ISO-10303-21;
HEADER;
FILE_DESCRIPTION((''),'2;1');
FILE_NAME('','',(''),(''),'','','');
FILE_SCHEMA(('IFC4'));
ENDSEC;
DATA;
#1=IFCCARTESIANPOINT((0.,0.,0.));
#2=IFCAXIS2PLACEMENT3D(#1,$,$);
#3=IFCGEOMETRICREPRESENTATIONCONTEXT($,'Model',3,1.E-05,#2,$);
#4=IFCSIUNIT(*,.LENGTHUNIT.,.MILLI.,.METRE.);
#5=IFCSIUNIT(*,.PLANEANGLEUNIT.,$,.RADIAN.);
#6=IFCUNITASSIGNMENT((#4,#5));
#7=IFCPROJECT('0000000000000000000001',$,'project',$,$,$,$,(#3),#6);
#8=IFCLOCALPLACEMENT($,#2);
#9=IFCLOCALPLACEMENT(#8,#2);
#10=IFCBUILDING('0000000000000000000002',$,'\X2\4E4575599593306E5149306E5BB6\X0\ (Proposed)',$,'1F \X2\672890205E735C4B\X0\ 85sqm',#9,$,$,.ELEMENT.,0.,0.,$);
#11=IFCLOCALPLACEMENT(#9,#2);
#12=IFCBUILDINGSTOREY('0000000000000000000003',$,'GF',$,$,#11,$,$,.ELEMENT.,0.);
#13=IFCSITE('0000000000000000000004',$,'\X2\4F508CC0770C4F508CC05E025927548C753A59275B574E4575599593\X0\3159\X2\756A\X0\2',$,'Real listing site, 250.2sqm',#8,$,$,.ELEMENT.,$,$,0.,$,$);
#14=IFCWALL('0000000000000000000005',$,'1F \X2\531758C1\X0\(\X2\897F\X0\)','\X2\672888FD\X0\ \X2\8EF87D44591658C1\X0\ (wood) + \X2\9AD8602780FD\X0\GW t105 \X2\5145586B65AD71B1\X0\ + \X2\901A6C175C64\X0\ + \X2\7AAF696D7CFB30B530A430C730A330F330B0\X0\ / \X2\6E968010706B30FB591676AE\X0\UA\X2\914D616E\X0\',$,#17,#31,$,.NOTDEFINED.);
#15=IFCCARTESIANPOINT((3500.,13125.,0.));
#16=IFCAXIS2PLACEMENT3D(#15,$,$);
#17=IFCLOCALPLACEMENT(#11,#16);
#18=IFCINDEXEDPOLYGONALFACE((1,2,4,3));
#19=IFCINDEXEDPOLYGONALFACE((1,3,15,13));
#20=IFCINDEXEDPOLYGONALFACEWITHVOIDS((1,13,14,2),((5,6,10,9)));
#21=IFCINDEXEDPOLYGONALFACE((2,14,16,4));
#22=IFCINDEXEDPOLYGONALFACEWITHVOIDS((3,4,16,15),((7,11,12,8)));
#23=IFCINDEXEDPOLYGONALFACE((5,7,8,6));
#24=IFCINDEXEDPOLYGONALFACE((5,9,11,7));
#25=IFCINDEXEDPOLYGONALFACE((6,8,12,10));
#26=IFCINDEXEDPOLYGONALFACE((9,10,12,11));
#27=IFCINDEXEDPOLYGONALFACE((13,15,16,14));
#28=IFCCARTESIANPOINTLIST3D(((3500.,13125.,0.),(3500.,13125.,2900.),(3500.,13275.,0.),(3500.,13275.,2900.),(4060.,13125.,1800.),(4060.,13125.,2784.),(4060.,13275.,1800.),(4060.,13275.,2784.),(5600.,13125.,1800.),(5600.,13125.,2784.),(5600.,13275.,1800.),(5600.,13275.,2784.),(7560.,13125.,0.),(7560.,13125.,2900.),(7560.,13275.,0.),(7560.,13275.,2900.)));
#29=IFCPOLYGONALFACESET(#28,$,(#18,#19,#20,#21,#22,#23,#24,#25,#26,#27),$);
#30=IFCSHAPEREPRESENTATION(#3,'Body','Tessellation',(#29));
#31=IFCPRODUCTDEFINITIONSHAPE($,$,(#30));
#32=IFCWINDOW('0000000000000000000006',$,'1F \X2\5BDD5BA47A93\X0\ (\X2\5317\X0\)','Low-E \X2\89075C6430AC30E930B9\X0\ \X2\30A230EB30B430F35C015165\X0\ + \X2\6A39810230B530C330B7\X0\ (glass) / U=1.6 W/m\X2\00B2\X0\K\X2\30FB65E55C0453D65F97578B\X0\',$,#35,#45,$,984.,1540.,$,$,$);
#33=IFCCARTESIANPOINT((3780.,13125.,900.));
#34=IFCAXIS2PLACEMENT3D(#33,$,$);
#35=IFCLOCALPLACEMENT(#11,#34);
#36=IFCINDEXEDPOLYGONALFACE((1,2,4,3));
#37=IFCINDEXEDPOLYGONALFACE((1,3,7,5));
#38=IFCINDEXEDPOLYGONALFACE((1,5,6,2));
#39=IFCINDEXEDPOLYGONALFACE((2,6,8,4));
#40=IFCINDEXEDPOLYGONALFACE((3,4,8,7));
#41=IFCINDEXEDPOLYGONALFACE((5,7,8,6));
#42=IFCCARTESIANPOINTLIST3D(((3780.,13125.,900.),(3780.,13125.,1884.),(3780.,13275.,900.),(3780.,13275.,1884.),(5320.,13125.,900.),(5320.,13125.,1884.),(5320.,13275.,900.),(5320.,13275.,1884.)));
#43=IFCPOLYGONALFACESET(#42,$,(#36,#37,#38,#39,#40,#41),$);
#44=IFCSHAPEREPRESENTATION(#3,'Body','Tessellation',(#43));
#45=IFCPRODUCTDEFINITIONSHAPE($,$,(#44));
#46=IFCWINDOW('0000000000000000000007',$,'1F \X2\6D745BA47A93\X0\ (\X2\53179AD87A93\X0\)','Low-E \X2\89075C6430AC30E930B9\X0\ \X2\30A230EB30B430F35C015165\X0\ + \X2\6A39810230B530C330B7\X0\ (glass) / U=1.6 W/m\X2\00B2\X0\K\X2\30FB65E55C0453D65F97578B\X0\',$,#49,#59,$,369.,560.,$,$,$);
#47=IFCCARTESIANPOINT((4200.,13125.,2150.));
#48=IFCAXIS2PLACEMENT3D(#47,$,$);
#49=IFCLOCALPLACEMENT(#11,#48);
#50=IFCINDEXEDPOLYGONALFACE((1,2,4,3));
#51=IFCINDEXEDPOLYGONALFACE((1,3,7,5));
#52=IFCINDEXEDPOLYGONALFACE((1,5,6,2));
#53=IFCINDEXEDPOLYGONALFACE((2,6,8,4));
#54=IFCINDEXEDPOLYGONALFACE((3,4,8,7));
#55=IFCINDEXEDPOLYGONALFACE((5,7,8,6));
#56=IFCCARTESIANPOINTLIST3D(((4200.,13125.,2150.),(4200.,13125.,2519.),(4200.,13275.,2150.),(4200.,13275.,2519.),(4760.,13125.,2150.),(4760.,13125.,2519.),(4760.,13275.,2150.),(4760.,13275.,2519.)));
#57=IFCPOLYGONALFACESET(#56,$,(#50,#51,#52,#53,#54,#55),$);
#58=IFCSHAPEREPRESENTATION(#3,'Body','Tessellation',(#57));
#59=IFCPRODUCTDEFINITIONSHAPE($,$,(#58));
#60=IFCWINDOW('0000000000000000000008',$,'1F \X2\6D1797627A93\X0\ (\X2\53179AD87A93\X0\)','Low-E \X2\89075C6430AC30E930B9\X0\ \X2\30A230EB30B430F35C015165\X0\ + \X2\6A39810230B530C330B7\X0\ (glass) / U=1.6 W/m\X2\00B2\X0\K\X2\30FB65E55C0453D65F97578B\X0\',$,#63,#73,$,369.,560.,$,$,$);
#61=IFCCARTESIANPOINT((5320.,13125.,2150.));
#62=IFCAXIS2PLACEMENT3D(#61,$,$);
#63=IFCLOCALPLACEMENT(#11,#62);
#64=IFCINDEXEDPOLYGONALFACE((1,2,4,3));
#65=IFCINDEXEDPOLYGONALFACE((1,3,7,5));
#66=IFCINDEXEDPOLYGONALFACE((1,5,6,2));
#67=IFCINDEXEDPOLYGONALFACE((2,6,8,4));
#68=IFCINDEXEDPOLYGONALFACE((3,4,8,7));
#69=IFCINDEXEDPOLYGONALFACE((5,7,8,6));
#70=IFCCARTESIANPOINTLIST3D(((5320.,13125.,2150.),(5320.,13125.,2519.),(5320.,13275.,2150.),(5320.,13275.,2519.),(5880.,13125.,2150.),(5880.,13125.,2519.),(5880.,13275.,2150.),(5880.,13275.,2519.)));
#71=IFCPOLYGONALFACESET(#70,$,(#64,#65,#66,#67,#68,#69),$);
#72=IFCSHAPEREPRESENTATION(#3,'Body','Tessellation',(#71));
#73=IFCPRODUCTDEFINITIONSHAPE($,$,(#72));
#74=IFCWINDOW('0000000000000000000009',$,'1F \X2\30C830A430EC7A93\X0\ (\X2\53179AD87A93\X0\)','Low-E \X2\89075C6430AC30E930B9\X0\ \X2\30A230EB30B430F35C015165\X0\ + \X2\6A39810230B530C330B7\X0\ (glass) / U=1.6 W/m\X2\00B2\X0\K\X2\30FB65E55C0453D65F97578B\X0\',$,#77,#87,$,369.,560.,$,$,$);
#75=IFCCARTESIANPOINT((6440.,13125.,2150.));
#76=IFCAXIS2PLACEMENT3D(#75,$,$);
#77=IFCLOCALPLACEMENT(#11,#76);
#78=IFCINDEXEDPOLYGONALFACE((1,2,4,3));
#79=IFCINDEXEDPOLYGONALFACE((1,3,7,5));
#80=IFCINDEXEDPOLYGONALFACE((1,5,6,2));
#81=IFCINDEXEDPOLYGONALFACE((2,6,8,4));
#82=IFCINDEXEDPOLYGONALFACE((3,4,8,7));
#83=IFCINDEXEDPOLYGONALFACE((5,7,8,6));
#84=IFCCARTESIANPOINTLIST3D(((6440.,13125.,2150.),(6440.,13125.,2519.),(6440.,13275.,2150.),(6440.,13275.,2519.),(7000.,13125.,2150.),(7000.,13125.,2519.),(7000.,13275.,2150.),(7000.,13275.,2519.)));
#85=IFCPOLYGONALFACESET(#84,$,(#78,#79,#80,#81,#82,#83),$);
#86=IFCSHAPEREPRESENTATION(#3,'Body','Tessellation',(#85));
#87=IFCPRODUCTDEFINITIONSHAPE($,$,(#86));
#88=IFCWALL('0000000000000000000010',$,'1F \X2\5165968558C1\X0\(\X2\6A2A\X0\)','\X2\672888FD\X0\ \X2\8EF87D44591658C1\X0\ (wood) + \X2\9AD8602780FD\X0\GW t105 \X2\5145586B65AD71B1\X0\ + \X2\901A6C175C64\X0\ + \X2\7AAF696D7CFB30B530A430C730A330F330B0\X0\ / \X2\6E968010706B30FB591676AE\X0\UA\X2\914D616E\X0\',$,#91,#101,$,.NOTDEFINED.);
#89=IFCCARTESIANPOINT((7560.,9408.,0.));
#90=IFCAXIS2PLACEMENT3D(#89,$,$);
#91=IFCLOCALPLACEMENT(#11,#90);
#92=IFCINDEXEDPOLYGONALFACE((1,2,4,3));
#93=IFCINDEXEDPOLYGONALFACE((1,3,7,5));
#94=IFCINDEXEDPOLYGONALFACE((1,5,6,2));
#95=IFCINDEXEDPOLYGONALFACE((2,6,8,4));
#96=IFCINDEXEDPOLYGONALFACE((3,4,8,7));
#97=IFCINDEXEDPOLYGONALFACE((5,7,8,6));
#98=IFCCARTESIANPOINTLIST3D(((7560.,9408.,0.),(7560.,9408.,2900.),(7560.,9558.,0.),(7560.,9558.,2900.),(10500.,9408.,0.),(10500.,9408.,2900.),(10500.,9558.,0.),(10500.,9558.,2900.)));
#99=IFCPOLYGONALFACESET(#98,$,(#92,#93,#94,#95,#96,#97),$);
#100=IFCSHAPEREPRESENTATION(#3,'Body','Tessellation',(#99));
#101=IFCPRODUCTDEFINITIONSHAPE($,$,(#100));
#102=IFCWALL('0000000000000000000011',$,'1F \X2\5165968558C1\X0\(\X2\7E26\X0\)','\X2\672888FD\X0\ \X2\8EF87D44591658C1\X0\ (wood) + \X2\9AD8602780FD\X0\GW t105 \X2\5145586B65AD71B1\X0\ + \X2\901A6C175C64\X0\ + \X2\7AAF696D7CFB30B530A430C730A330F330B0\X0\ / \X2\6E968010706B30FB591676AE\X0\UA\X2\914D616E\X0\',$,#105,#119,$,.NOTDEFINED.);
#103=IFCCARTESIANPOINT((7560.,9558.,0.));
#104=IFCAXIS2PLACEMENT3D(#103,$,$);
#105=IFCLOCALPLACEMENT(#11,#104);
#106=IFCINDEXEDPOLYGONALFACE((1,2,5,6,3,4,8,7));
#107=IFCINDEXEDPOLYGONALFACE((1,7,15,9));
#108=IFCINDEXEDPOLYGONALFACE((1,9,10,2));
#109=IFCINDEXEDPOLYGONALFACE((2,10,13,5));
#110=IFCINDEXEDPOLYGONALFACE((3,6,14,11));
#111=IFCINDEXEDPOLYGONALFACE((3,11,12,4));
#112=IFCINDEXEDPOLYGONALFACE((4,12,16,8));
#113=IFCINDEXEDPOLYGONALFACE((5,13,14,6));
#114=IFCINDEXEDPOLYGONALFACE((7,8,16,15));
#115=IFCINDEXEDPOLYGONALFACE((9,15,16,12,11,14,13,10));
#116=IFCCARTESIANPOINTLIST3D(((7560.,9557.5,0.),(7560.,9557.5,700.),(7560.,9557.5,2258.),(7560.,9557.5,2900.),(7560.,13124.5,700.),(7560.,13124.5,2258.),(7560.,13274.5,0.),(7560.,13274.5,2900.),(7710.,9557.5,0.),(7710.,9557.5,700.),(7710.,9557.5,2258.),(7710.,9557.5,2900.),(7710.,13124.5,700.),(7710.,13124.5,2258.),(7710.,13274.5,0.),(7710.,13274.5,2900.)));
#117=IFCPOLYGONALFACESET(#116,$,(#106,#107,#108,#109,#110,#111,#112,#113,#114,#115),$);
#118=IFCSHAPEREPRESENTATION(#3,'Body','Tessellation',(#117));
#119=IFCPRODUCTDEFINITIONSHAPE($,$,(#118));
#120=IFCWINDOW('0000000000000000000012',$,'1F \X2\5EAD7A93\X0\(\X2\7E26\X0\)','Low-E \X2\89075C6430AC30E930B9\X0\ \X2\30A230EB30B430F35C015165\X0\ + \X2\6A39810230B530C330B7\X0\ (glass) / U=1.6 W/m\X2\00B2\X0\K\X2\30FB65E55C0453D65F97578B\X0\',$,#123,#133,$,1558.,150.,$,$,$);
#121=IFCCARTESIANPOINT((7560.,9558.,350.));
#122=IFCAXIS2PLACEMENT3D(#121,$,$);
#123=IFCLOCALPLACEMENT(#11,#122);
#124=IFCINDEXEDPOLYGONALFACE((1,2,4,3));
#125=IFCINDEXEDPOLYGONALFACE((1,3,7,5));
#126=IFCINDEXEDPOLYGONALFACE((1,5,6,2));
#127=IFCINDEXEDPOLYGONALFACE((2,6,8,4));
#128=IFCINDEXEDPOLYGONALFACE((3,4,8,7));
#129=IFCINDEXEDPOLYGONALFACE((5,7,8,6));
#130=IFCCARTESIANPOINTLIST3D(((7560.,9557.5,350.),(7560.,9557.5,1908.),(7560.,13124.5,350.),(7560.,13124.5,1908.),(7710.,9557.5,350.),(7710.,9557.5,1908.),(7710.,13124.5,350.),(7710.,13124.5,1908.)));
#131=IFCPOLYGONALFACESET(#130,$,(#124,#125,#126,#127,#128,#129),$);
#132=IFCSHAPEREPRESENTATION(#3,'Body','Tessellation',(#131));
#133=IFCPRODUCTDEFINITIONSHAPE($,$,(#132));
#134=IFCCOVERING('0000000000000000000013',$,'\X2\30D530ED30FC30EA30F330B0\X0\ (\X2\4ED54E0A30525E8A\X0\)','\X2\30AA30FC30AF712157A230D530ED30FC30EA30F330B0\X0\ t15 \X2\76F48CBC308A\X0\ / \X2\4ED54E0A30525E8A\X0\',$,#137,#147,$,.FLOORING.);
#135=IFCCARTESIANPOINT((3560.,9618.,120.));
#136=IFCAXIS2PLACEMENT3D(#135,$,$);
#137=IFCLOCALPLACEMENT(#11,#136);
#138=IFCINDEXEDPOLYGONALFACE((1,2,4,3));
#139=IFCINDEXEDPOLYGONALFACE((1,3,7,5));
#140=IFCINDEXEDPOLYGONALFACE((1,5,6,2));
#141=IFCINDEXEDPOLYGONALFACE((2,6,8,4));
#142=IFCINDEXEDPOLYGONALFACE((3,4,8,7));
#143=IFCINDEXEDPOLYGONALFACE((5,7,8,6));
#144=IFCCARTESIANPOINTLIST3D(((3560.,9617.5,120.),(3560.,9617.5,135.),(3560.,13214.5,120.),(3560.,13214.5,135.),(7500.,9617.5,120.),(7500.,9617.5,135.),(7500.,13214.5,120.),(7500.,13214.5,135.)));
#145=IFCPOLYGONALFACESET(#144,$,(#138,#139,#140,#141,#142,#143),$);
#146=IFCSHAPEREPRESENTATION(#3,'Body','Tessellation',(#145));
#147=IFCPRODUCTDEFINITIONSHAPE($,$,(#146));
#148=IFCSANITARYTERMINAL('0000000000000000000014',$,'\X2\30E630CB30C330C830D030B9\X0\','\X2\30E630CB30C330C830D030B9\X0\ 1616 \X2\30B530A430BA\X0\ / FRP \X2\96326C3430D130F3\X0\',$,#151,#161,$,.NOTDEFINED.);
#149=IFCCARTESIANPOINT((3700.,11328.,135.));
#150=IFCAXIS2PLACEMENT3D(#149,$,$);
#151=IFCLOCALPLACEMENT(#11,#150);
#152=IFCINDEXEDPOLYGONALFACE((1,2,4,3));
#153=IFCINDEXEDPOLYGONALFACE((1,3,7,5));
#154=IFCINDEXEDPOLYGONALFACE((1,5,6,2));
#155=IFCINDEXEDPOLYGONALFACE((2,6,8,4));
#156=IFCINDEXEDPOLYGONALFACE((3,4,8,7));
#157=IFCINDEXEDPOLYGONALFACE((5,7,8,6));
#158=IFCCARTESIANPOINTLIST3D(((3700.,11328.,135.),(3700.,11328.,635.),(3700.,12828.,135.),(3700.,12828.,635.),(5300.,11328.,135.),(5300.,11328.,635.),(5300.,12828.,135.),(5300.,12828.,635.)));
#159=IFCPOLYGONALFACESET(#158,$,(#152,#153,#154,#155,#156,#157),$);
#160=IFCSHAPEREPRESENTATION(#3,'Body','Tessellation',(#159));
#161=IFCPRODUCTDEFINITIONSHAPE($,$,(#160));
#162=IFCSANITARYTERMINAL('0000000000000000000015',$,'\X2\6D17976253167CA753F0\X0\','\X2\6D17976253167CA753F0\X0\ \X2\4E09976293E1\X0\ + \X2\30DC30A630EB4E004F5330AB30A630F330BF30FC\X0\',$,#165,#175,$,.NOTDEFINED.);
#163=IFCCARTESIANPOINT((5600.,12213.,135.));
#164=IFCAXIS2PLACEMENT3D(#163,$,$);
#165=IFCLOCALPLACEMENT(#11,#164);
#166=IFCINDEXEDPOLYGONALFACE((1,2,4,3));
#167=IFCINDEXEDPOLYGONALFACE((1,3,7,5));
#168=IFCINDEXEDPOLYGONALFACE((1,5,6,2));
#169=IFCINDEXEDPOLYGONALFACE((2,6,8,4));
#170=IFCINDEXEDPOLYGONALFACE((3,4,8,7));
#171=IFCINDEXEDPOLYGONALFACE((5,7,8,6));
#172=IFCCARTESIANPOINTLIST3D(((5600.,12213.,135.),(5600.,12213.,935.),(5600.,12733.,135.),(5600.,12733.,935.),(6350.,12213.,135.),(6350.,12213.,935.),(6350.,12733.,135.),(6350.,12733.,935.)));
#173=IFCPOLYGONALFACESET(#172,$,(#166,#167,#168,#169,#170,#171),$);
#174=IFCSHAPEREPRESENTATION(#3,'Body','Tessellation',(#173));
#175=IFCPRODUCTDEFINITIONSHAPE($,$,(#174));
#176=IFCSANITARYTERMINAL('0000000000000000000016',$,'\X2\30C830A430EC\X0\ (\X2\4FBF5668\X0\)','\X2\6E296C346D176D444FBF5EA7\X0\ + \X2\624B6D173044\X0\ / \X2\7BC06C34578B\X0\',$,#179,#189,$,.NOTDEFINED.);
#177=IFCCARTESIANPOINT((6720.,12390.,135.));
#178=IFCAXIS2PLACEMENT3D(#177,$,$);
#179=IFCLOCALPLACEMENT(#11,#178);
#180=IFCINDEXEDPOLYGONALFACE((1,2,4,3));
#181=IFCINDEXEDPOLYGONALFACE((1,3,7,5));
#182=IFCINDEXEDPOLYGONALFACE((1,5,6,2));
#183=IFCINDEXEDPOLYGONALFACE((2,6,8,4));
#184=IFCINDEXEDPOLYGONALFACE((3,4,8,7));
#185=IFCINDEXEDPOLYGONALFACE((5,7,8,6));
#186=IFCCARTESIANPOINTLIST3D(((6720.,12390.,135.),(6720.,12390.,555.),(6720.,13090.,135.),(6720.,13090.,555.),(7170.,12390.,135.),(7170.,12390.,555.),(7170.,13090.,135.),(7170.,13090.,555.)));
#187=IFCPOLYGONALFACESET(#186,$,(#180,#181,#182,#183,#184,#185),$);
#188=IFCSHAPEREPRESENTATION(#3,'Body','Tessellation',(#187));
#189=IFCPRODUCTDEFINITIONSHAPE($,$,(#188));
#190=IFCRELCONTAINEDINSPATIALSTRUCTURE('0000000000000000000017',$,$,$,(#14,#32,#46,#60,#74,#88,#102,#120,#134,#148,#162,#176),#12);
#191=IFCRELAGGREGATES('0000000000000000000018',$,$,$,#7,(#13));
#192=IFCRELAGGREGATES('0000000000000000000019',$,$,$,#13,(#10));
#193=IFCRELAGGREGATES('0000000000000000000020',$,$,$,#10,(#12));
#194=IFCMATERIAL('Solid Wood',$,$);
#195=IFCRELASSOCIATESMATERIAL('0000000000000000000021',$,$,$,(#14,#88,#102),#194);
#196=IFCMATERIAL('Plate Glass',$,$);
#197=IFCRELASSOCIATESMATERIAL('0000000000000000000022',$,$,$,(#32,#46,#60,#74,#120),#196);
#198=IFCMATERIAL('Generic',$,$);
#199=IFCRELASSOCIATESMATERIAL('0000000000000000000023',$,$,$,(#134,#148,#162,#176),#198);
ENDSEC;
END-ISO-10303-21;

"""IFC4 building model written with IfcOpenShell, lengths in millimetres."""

from ifc_helpers import new_model, si_unit, frame, frame_2d, origin, place, context, project, spatial, rectangle, extrude, material, element, fill, save


model = new_model("IFC4")

# Units and contexts
model_context = context("Model", 3, precision=1e-05, world=origin())
ifc_project = project(units=[si_unit("LENGTHUNIT", "METRE", prefix="MILLI"), si_unit("PLANEANGLEUNIT", "RADIAN")], contexts=[model_context])

# Site, building, storey
site_placement = place(None, origin())
site = spatial("IfcSite", under=ifc_project, at=site_placement, Name="佐賀県佐賀市大和町大字久留間3159番2", ObjectType="Real listing site, 250.2sqm", CompositionType="ELEMENT", RefElevation=0.0)
building_placement = place(site_placement, origin())
building = spatial("IfcBuilding", under=site, at=building_placement, Name="久留間の光の家 (Proposed)", ObjectType="1F 木造平屋 85sqm", CompositionType="ELEMENT", ElevationOfRefHeight=0.0, ElevationOfTerrain=0.0)
storey_placement = place(building_placement, origin())
storey = spatial("IfcBuildingStorey", under=building, at=storey_placement, Name="GF", CompositionType="ELEMENT", Elevation=0.0)

# Shared definitions
ifc_material_1 = material(Name="Solid Wood")

# Wall, openings, windows
wall_1_placement = place(storey_placement, frame((3500.0, 13125.0, 0.0)))
wall_1 = element("IfcWall", 1, at=wall_1_placement, inside=storey, material=ifc_material_1, Name="1F 北壁(西)", Description="木製 軸組外壁 (wood) + 高性能GW t105 充填断熱 + 通気層 + 窯業系サイディング / 準耐火・外皮UA配慮", PredefinedType="NOTDEFINED", context=model_context, shape_type="SweptSolid", body=[
    extrude(rectangle(XDim=4060.0, YDim=150.0, at=frame_2d((2030.0, 75.0))), frame((3500.0, 13125.0, 0.0)), (0.0, 0.0, 1.0), 2900.0),
])
opening_1_placement = place(storey_placement, frame((3780.0, 13125.0, 900.0)))
opening_1 = element("IfcOpeningElement", 2, at=opening_1_placement, cuts=wall_1, PredefinedType="NOTDEFINED", context=model_context, shape_type="SweptSolid", body=[
    extrude(rectangle(XDim=1540.0, YDim=150.0, at=frame_2d((770.0, 75.0))), frame((3780.0, 13125.0, 900.0)), (0.0, 0.0, 1.0), 984.0),
])
opening_2_placement = place(storey_placement, frame((4200.0, 13125.0, 2150.0)))
opening_2 = element("IfcOpeningElement", 3, at=opening_2_placement, cuts=wall_1, PredefinedType="NOTDEFINED", context=model_context, shape_type="SweptSolid", body=[
    extrude(rectangle(XDim=560.0, YDim=150.0, at=frame_2d((280.0, 75.0))), frame((4200.0, 13125.0, 2150.0)), (0.0, 0.0, 1.0), 369.0),
])
opening_3_placement = place(storey_placement, frame((5320.0, 13125.0, 2150.0)))
opening_3 = element("IfcOpeningElement", 4, at=opening_3_placement, cuts=wall_1, PredefinedType="NOTDEFINED", context=model_context, shape_type="SweptSolid", body=[
    extrude(rectangle(XDim=560.0, YDim=150.0, at=frame_2d((280.0, 75.0))), frame((5320.0, 13125.0, 2150.0)), (0.0, 0.0, 1.0), 369.0),
])
opening_4_placement = place(storey_placement, frame((6440.0, 13125.0, 2150.0)))
opening_4 = element("IfcOpeningElement", 5, at=opening_4_placement, cuts=wall_1, PredefinedType="NOTDEFINED", context=model_context, shape_type="SweptSolid", body=[
    extrude(rectangle(XDim=560.0, YDim=150.0, at=frame_2d((280.0, 75.0))), frame((6440.0, 13125.0, 2150.0)), (0.0, 0.0, 1.0), 369.0),
])
ifc_material_2 = material(Name="Plate Glass")
window_1_placement = place(storey_placement, frame((3780.0, 13125.0, 900.0)))
window_1 = element("IfcWindow", 6, at=window_1_placement, inside=storey, material=ifc_material_2, Name="1F 寝室窓 (北)", Description="Low-E 複層ガラス アルゴン封入 + 樹脂サッシ (glass) / U=1.6 W/m²K・日射取得型", OverallHeight=984.0, OverallWidth=1540.0, context=model_context, shape_type="SweptSolid", body=[
    extrude(rectangle(XDim=1540.0, YDim=150.0, at=frame_2d((770.0, 75.0))), frame((3780.0, 13125.0, 900.0)), (0.0, 0.0, 1.0), 984.0),
])
fill(opening_1, window_1)
window_2_placement = place(storey_placement, frame((4200.0, 13125.0, 2150.0)))
window_2 = element("IfcWindow", 7, at=window_2_placement, inside=storey, material=ifc_material_2, Name="1F 浴室窓 (北高窓)", Description="Low-E 複層ガラス アルゴン封入 + 樹脂サッシ (glass) / U=1.6 W/m²K・日射取得型", OverallHeight=369.0, OverallWidth=560.0, context=model_context, shape_type="SweptSolid", body=[
    extrude(rectangle(XDim=560.0, YDim=150.0, at=frame_2d((280.0, 75.0))), frame((4200.0, 13125.0, 2150.0)), (0.0, 0.0, 1.0), 369.0),
])
fill(opening_2, window_2)
window_3_placement = place(storey_placement, frame((5320.0, 13125.0, 2150.0)))
window_3 = element("IfcWindow", 8, at=window_3_placement, inside=storey, material=ifc_material_2, Name="1F 洗面窓 (北高窓)", Description="Low-E 複層ガラス アルゴン封入 + 樹脂サッシ (glass) / U=1.6 W/m²K・日射取得型", OverallHeight=369.0, OverallWidth=560.0, context=model_context, shape_type="SweptSolid", body=[
    extrude(rectangle(XDim=560.0, YDim=150.0, at=frame_2d((280.0, 75.0))), frame((5320.0, 13125.0, 2150.0)), (0.0, 0.0, 1.0), 369.0),
])
fill(opening_3, window_3)
window_4_placement = place(storey_placement, frame((6440.0, 13125.0, 2150.0)))
window_4 = element("IfcWindow", 9, at=window_4_placement, inside=storey, material=ifc_material_2, Name="1F トイレ窓 (北高窓)", Description="Low-E 複層ガラス アルゴン封入 + 樹脂サッシ (glass) / U=1.6 W/m²K・日射取得型", OverallHeight=369.0, OverallWidth=560.0, context=model_context, shape_type="SweptSolid", body=[
    extrude(rectangle(XDim=560.0, YDim=150.0, at=frame_2d((280.0, 75.0))), frame((6440.0, 13125.0, 2150.0)), (0.0, 0.0, 1.0), 369.0),
])
fill(opening_4, window_4)

# Wall
wall_2_placement = place(storey_placement, frame((7560.0, 9408.0, 0.0)))
element("IfcWall", 10, at=wall_2_placement, inside=storey, material=ifc_material_1, Name="1F 入隅壁(横)", Description="木製 軸組外壁 (wood) + 高性能GW t105 充填断熱 + 通気層 + 窯業系サイディング / 準耐火・外皮UA配慮", PredefinedType="NOTDEFINED", context=model_context, shape_type="SweptSolid", body=[
    extrude(rectangle(XDim=2940.0, YDim=150.0, at=frame_2d((1470.0, 75.0))), frame((7560.0, 9408.0, 0.0)), (0.0, 0.0, 1.0), 2900.0),
])

# Wall, opening, window
wall_3_placement = place(storey_placement, frame((7560.0, 9558.0, 0.0)))
wall_3 = element("IfcWall", 11, at=wall_3_placement, inside=storey, material=ifc_material_1, Name="1F 入隅壁(縦)", Description="木製 軸組外壁 (wood) + 高性能GW t105 充填断熱 + 通気層 + 窯業系サイディング / 準耐火・外皮UA配慮", PredefinedType="NOTDEFINED", context=model_context, shape_type="SweptSolid", body=[
    extrude(rectangle(XDim=150.0, YDim=3717.0, at=frame_2d((75.0, 1858.0))), frame((7560.0, 9558.0, 0.0)), (0.0, 0.0, 1.0), 2900.0),
])
opening_5_placement = place(storey_placement, frame((7560.0, 9558.0, 350.0)))
opening_5 = element("IfcOpeningElement", 12, at=opening_5_placement, cuts=wall_3, PredefinedType="NOTDEFINED", context=model_context, shape_type="SweptSolid", body=[
    extrude(rectangle(XDim=150.0, YDim=3567.0, at=frame_2d((75.0, 1783.0))), frame((7560.0, 9558.0, 350.0)), (0.0, 0.0, 1.0), 1558.0),
])
window_5_placement = place(storey_placement, frame((7560.0, 9558.0, 350.0)))
window_5 = element("IfcWindow", 13, at=window_5_placement, inside=storey, material=ifc_material_2, Name="1F 庭窓(縦)", Description="Low-E 複層ガラス アルゴン封入 + 樹脂サッシ (glass) / U=1.6 W/m²K・日射取得型", OverallHeight=1558.0, OverallWidth=150.0, context=model_context, shape_type="SweptSolid", body=[
    extrude(rectangle(XDim=150.0, YDim=3567.0, at=frame_2d((75.0, 1783.0))), frame((7560.0, 9558.0, 350.0)), (0.0, 0.0, 1.0), 1558.0),
])
fill(opening_5, window_5)

# Covering
ifc_material_3 = material(Name="Generic")
covering_placement = place(storey_placement, frame((3560.0, 9618.0, 120.0)))
element("IfcCovering", 14, at=covering_placement, inside=storey, material=ifc_material_3, Name="フローリング (仕上げ床)", Description="オーク無垢フローリング t15 直貼り / 仕上げ床", PredefinedType="FLOORING", context=model_context, shape_type="SweptSolid", body=[
    extrude(rectangle(XDim=3940.0, YDim=3597.0, at=frame_2d((1970.0, 1798.0))), frame((3560.0, 9618.0, 120.0)), (0.0, 0.0, 1.0), 15.0),
])

# Sanitary terminals
sanitary_terminal_1_placement = place(storey_placement, frame((3700.0, 11328.0, 135.0)))
element("IfcSanitaryTerminal", 15, at=sanitary_terminal_1_placement, inside=storey, material=ifc_material_3, Name="ユニットバス", Description="ユニットバス 1616 サイズ / FRP 防水パン", PredefinedType="NOTDEFINED", context=model_context, shape_type="SweptSolid", body=[
    extrude(rectangle(XDim=1600.0, YDim=1500.0, at=frame_2d((800.0, 750.0))), frame((3700.0, 11328.0, 135.0)), (0.0, 0.0, 1.0), 500.0),
])
sanitary_terminal_2_placement = place(storey_placement, frame((5600.0, 12213.0, 135.0)))
element("IfcSanitaryTerminal", 16, at=sanitary_terminal_2_placement, inside=storey, material=ifc_material_3, Name="洗面化粧台", Description="洗面化粧台 三面鏡 + ボウル一体カウンター", PredefinedType="NOTDEFINED", context=model_context, shape_type="SweptSolid", body=[
    extrude(rectangle(XDim=750.0, YDim=520.0, at=frame_2d((375.0, 260.0))), frame((5600.0, 12213.0, 135.0)), (0.0, 0.0, 1.0), 800.0),
])
sanitary_terminal_3_placement = place(storey_placement, frame((6720.0, 12390.0, 135.0)))
element("IfcSanitaryTerminal", 17, at=sanitary_terminal_3_placement, inside=storey, material=ifc_material_3, Name="トイレ (便器)", Description="温水洗浄便座 + 手洗い / 節水型", PredefinedType="NOTDEFINED", context=model_context, shape_type="SweptSolid", body=[
    extrude(rectangle(XDim=450.0, YDim=700.0, at=frame_2d((225.0, 350.0))), frame((6720.0, 12390.0, 135.0)), (0.0, 0.0, 1.0), 420.0),
])

save(model, "model.ifc")
